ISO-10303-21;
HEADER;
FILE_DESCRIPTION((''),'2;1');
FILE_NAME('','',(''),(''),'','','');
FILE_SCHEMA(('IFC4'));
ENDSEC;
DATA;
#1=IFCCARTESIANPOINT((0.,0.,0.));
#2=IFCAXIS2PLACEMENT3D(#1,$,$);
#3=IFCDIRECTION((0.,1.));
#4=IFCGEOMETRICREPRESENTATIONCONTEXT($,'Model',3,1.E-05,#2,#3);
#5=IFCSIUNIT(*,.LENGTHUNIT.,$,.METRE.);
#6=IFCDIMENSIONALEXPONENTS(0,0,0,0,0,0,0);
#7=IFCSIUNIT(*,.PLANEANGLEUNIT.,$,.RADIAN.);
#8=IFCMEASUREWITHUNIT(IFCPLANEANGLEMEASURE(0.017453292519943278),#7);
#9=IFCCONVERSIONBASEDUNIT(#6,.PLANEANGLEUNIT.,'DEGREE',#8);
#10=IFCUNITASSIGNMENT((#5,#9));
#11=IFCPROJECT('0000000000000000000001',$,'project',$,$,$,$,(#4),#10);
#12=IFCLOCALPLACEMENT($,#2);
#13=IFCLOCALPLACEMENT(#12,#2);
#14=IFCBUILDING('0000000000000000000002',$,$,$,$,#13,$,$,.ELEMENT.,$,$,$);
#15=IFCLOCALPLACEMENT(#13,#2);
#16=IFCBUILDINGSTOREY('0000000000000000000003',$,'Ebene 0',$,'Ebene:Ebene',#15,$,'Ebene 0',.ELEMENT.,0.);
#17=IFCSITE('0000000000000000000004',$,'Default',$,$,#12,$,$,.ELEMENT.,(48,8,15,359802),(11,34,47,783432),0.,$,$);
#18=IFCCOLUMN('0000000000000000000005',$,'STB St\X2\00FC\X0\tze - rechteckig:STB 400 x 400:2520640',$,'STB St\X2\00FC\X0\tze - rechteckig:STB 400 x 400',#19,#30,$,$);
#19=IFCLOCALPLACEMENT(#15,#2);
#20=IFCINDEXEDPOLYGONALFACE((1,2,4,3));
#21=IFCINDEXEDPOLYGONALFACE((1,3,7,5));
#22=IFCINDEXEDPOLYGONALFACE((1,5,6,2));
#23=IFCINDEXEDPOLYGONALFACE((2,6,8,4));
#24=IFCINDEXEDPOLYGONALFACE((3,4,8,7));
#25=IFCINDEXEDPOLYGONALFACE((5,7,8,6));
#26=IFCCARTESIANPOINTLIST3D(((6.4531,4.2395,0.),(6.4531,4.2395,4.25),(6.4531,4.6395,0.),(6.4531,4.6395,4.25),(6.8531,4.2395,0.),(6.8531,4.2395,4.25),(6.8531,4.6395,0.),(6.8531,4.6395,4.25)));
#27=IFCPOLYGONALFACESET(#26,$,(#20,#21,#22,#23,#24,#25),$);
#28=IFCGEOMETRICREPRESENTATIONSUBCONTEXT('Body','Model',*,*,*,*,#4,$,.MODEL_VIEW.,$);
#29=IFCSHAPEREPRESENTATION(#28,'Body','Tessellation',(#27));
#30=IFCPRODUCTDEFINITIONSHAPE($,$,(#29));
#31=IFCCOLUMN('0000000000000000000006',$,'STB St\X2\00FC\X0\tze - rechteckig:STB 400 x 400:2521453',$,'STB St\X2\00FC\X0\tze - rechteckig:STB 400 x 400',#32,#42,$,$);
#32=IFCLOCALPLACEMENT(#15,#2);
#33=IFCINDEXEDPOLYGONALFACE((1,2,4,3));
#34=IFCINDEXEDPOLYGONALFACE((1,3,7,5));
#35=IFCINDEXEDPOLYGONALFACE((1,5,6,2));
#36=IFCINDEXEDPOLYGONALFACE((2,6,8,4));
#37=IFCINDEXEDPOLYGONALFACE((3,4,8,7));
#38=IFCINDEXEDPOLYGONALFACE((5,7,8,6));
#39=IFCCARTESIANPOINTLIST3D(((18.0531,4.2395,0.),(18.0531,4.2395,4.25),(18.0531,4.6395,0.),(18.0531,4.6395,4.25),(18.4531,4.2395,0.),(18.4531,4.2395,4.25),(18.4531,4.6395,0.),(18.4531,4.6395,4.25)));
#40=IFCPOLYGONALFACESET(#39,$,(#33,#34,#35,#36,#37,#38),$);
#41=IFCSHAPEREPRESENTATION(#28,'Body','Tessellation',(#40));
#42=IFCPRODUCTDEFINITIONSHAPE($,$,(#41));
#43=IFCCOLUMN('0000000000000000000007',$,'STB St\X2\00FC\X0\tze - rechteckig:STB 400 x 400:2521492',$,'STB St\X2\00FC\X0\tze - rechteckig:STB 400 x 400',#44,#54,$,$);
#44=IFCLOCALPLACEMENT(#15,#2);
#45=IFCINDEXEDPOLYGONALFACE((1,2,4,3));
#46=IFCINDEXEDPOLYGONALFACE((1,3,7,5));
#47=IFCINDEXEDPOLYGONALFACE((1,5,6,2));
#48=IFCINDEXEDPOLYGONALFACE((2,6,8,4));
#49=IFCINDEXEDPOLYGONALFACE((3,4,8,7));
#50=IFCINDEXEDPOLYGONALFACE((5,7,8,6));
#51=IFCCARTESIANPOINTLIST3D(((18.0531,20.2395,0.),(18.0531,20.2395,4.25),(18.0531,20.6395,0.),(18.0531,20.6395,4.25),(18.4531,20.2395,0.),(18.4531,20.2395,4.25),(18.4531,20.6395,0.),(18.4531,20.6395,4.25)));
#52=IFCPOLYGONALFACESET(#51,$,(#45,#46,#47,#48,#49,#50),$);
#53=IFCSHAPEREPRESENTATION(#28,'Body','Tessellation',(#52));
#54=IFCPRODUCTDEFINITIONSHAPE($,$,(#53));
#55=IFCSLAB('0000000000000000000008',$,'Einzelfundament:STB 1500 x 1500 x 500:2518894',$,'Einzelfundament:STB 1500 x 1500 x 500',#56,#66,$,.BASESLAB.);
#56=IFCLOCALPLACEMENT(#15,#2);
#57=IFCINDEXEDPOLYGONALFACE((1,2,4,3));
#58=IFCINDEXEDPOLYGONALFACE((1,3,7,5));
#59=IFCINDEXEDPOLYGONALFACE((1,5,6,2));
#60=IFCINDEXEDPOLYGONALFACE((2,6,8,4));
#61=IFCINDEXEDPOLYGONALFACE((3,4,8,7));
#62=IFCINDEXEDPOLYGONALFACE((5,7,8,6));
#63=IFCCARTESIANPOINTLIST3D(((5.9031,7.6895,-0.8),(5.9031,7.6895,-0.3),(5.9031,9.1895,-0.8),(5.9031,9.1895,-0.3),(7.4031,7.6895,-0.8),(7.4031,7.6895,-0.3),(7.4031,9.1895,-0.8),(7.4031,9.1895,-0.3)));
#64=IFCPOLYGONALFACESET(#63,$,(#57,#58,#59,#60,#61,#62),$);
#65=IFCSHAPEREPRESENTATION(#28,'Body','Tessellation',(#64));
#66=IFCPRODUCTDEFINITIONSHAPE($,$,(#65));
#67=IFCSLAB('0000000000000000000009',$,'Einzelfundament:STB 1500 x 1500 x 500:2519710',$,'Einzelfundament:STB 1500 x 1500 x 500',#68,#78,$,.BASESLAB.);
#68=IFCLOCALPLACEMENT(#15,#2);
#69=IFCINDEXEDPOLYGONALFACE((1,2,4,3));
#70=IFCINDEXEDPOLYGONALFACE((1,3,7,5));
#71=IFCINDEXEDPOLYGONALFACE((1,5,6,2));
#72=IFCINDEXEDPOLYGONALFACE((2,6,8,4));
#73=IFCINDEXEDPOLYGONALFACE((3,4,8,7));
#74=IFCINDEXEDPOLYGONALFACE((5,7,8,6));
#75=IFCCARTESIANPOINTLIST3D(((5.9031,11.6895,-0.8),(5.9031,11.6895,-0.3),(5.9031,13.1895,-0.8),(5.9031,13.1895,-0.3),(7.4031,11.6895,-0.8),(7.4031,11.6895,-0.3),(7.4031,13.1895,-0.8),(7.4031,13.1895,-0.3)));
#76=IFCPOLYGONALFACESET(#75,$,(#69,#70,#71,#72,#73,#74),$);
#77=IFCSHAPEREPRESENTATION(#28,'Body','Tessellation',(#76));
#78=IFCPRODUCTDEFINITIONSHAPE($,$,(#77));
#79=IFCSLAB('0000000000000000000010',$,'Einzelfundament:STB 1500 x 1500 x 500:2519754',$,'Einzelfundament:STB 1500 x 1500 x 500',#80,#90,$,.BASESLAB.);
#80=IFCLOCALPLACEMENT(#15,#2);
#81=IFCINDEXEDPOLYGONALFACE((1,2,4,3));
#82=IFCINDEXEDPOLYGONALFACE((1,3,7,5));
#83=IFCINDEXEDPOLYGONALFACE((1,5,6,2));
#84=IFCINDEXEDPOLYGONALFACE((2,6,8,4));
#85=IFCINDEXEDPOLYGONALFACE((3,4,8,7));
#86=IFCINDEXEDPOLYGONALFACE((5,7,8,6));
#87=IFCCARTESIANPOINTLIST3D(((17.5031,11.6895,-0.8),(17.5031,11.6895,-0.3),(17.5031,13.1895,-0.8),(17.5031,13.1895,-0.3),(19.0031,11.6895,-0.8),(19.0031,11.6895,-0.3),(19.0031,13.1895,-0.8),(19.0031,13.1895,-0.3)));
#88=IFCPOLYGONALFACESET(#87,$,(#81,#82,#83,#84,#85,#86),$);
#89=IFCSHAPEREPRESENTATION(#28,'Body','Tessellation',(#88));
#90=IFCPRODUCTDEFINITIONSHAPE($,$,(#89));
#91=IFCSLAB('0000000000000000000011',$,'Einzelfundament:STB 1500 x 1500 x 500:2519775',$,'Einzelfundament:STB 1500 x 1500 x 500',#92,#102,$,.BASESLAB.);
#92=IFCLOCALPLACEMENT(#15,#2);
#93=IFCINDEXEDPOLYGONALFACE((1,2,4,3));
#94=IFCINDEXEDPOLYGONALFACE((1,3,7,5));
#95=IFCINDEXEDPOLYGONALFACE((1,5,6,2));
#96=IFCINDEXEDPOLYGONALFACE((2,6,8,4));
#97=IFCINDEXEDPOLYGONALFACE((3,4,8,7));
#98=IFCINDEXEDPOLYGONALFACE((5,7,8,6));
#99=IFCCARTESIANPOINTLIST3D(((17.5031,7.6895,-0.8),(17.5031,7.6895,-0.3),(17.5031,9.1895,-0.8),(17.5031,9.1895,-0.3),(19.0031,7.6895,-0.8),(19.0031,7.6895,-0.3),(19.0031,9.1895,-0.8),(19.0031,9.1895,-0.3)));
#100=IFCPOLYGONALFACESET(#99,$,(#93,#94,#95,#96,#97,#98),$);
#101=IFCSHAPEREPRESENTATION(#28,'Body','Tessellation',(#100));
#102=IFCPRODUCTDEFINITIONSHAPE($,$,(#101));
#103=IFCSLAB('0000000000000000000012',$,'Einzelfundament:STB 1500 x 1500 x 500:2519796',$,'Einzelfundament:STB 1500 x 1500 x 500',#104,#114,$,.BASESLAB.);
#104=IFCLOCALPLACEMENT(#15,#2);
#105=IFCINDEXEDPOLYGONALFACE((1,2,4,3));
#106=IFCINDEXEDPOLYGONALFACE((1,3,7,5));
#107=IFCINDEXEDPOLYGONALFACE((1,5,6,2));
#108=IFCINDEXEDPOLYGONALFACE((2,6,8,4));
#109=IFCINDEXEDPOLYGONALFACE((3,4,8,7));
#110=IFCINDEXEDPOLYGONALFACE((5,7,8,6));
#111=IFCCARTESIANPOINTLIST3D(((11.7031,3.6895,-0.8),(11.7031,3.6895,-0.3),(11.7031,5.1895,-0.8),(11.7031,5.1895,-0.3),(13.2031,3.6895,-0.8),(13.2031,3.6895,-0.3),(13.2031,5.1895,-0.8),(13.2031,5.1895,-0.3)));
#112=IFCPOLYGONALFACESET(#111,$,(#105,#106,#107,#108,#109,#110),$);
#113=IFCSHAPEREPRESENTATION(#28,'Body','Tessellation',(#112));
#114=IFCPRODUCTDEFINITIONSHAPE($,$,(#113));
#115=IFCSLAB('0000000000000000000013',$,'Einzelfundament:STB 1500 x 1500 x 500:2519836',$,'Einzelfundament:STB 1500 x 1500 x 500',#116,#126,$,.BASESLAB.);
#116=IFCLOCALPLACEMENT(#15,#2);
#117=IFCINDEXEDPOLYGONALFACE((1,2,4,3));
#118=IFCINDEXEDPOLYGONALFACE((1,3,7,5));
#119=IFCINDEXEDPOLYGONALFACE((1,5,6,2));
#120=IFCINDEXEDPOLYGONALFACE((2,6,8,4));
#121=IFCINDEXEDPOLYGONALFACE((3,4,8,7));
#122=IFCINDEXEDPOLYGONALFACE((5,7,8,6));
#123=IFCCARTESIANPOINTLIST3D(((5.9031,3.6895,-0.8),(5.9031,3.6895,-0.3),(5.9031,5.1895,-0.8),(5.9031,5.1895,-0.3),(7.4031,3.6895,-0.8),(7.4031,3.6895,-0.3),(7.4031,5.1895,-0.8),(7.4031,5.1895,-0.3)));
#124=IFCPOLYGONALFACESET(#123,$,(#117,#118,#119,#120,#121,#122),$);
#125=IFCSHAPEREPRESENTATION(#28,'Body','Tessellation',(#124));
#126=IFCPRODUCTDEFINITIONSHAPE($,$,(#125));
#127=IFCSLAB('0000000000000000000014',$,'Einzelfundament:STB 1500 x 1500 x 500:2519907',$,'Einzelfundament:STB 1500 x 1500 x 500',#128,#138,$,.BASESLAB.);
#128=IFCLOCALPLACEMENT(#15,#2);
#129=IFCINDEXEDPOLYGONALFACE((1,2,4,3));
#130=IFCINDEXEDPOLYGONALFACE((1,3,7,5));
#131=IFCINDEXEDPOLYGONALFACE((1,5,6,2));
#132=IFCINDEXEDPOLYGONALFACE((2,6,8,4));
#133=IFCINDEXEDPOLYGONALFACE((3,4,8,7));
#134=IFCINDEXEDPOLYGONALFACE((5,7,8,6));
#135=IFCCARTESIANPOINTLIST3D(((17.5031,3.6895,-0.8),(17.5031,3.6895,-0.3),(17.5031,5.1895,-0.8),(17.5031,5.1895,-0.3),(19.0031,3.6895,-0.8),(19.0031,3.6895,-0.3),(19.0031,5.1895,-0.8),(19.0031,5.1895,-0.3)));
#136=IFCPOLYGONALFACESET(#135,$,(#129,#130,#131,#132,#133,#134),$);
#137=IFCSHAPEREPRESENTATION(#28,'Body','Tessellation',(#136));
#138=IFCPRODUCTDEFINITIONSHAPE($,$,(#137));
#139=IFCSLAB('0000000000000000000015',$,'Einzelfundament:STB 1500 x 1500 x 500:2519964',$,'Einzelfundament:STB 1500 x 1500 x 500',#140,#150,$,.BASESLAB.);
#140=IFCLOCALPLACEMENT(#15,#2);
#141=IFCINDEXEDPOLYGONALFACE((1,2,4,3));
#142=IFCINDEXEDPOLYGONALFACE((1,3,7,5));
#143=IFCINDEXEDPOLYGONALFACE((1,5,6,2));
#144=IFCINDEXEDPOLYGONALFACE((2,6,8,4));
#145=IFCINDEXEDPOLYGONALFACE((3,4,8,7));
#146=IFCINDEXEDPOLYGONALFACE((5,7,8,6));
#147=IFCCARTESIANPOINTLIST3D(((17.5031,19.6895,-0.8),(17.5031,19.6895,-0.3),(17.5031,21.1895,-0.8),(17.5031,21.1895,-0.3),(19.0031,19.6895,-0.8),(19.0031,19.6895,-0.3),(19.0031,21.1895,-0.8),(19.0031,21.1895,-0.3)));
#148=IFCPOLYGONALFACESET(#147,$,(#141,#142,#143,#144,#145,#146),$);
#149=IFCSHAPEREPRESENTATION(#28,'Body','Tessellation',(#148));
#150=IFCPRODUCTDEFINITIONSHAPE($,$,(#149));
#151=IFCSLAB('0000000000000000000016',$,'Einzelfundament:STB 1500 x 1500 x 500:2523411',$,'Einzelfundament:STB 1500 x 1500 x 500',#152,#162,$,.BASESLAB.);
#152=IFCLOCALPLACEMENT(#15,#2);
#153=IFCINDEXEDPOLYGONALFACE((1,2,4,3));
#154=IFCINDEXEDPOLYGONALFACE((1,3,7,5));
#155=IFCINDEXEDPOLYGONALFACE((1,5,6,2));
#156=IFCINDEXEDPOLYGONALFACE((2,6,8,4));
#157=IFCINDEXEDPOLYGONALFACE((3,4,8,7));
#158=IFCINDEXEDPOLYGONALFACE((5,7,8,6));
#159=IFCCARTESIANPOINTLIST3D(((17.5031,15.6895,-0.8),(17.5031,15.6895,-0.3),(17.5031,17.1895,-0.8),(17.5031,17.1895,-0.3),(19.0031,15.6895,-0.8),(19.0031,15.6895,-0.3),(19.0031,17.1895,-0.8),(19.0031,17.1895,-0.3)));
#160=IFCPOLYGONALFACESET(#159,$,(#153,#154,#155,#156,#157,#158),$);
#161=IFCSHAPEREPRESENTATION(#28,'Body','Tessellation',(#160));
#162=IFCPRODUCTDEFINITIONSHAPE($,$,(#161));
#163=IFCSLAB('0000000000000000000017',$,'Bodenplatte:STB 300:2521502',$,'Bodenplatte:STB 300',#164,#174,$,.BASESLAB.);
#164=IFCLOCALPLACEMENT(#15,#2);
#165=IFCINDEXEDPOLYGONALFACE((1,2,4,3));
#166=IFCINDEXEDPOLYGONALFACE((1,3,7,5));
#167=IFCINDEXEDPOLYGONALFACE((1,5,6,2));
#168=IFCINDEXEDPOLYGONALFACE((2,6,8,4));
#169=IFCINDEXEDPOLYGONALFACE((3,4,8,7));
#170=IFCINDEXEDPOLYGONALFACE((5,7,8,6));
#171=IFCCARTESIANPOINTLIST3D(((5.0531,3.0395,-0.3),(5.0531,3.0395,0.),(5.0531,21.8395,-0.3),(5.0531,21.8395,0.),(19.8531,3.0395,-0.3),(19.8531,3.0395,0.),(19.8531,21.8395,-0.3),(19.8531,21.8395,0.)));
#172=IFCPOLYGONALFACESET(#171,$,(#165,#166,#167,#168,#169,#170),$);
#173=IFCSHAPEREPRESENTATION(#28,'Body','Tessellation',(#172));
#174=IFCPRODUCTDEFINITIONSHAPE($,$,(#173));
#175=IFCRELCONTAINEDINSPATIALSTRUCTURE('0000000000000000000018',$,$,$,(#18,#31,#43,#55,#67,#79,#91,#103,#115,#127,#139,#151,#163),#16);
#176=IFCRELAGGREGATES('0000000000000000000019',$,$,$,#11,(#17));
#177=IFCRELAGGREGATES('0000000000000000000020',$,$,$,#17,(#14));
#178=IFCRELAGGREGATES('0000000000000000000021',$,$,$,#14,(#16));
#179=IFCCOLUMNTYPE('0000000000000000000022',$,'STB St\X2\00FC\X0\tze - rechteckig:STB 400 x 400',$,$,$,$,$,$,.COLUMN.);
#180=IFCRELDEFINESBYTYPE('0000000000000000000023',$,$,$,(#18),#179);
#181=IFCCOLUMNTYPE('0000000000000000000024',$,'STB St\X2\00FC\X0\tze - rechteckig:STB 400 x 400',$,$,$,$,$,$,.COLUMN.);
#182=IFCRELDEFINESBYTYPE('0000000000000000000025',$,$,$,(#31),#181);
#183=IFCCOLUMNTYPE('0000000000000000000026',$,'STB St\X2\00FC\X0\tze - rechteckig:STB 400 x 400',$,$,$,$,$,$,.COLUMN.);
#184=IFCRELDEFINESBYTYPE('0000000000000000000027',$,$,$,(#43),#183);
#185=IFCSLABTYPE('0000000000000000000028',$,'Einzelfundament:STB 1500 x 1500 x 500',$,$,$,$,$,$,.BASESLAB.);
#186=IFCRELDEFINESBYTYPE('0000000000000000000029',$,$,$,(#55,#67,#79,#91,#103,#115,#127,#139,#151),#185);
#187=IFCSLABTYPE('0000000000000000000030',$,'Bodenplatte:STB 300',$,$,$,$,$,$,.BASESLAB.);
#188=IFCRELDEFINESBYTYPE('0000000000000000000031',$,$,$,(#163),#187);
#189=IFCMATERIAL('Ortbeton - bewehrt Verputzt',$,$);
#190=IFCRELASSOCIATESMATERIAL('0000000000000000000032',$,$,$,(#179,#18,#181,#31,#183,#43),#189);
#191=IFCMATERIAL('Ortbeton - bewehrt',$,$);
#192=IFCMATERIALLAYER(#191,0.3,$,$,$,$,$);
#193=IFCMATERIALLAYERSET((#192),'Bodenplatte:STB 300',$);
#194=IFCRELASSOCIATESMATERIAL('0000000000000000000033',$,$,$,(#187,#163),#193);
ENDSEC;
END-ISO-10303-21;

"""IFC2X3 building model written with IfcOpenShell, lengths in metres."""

from ifc_helpers import new_model, entity, si_unit, converted_unit, direction, frame, frame_2d, origin, origin_2d_with_axis, place, context, subcontext, project, spatial, rectangle, extrude, source, transform, mapped, material, layer, layer_set, layer_usage, type_object, type_shapes, element, save


model = new_model("IFC2X3")

# Units and contexts
model_context = context("Model", 3, precision=1e-05, world=origin(), true_north=direction((0.0, 1.0)))
body_context = subcontext(model_context, "Body", "Model", "MODEL_VIEW")
ifc_project = project(units=[si_unit("LENGTHUNIT", "METRE"), converted_unit("PLANEANGLEUNIT", "DEGREE", entity("IfcPlaneAngleMeasure", 0.017453292519943278), si_unit("PLANEANGLEUNIT", "RADIAN"), dimensions=[0, 0, 0, 0, 0, 0, 0])], contexts=[model_context])

# Site, building, storey
site_placement = place(None, origin())
site = spatial("IfcSite", under=ifc_project, at=site_placement, Name="Default", CompositionType="ELEMENT", RefLatitude=(48, 8, 15, 359802), RefLongitude=(11, 34, 47, 783432), RefElevation=0.0)
building_placement = place(site_placement, origin())
building = spatial("IfcBuilding", under=site, at=building_placement, CompositionType="ELEMENT")
storey_placement = place(building_placement, origin())
storey = spatial("IfcBuildingStorey", under=building, at=storey_placement, Name="Ebene 0", ObjectType="Ebene:Ebene", LongName="Ebene 0", CompositionType="ELEMENT", Elevation=0.0)

# Columns
ifc_material_1 = material(Name="Ortbeton - bewehrt Verputzt")
column_type_1 = type_object("IfcColumnType", Name="STB Stütze - rechteckig:STB 400 x 400", PredefinedType="COLUMN", material=ifc_material_1)
shared_shape_1 = source(origin(), body_context, "Body", "SweptSolid", [
    extrude(rectangle(XDim=0.4, YDim=0.4, at=origin_2d_with_axis()), frame((6.6531, 4.4395, 0.0), z_axis=(0.0, 0.0, 1.0), x_axis=(-1.0, 0.0, 0.0)), (0.0, 0.0, 1.0), 4.25),
])
type_shapes(column_type_1, [shared_shape_1])
column_1_placement = place(storey_placement, origin())
element("IfcColumn", 1, at=column_1_placement, inside=storey, type_object=column_type_1, material=ifc_material_1, Name="STB Stütze - rechteckig:STB 400 x 400:2520640", ObjectType="STB Stütze - rechteckig:STB 400 x 400", context=body_context, shape_type="MappedRepresentation", body=[
    mapped(shared_shape_1, transform((0.0, 0.0, 0.0), scale=1.0)),
])
column_type_2 = type_object("IfcColumnType", Name="STB Stütze - rechteckig:STB 400 x 400", PredefinedType="COLUMN", material=ifc_material_1)
shared_shape_2 = source(origin(), body_context, "Body", "SweptSolid", [
    extrude(rectangle(XDim=0.4, YDim=0.4, at=origin_2d_with_axis()), frame((18.2531, 4.4395, 0.0), z_axis=(0.0, 0.0, 1.0), x_axis=(-1.0, 0.0, 0.0)), (0.0, 0.0, 1.0), 4.25),
])
type_shapes(column_type_2, [shared_shape_2])
column_2_placement = place(storey_placement, origin())
element("IfcColumn", 2, at=column_2_placement, inside=storey, type_object=column_type_2, material=ifc_material_1, Name="STB Stütze - rechteckig:STB 400 x 400:2521453", ObjectType="STB Stütze - rechteckig:STB 400 x 400", context=body_context, shape_type="MappedRepresentation", body=[
    mapped(shared_shape_2, transform((0.0, 0.0, 0.0), scale=1.0)),
])
column_type_3 = type_object("IfcColumnType", Name="STB Stütze - rechteckig:STB 400 x 400", PredefinedType="COLUMN", material=ifc_material_1)
shared_shape_3 = source(origin(), body_context, "Body", "SweptSolid", [
    extrude(rectangle(XDim=0.4, YDim=0.4, at=frame_2d((0.0, 0.0), x_axis=(1.0, 0.0))), frame((18.2531, 20.4395, 0.0), z_axis=(0.0, 0.0, 1.0), x_axis=(-1.0, 0.0, 0.0)), (0.0, 0.0, 1.0), 4.25),
])
type_shapes(column_type_3, [shared_shape_3])
column_3_placement = place(storey_placement, origin())
element("IfcColumn", 3, at=column_3_placement, inside=storey, type_object=column_type_3, material=ifc_material_1, Name="STB Stütze - rechteckig:STB 400 x 400:2521492", ObjectType="STB Stütze - rechteckig:STB 400 x 400", context=body_context, shape_type="MappedRepresentation", body=[
    mapped(shared_shape_3, transform((0.0, 0.0, 0.0), scale=1.0)),
])

# Slabs
slab_type_1 = type_object("IfcSlabType", Name="Einzelfundament:STB 1500 x 1500 x 500", PredefinedType="BASESLAB")
slab_1_placement = place(storey_placement, origin())
element("IfcSlab", 4, at=slab_1_placement, inside=storey, type_object=slab_type_1, Name="Einzelfundament:STB 1500 x 1500 x 500:2518894", ObjectType="Einzelfundament:STB 1500 x 1500 x 500", PredefinedType="BASESLAB", context=body_context, shape_type="SweptSolid", body=[
    extrude(rectangle(XDim=1.5, YDim=1.5, at=frame_2d((0.0, 0.0), x_axis=(1.0, 0.0))), frame((6.6531, 8.4395, -0.8), z_axis=(0.0, 0.0, 1.0), x_axis=(-1.0, 0.0, 0.0)), (0.0, 0.0, 1.0), 0.5),
])
slab_2_placement = place(storey_placement, origin())
element("IfcSlab", 5, at=slab_2_placement, inside=storey, type_object=slab_type_1, Name="Einzelfundament:STB 1500 x 1500 x 500:2519710", ObjectType="Einzelfundament:STB 1500 x 1500 x 500", PredefinedType="BASESLAB", context=body_context, shape_type="SweptSolid", body=[
    extrude(rectangle(XDim=1.5, YDim=1.5, at=frame_2d((0.0, 0.0), x_axis=(1.0, 0.0))), frame((6.6531, 12.4395, -0.8), z_axis=(0.0, 0.0, 1.0), x_axis=(-1.0, 0.0, 0.0)), (0.0, 0.0, 1.0), 0.5),
])
slab_3_placement = place(storey_placement, origin())
element("IfcSlab", 6, at=slab_3_placement, inside=storey, type_object=slab_type_1, Name="Einzelfundament:STB 1500 x 1500 x 500:2519754", ObjectType="Einzelfundament:STB 1500 x 1500 x 500", PredefinedType="BASESLAB", context=body_context, shape_type="SweptSolid", body=[
    extrude(rectangle(XDim=1.5, YDim=1.5, at=frame_2d((0.0, 0.0), x_axis=(1.0, 0.0))), frame((18.2531, 12.4395, -0.8), z_axis=(0.0, 0.0, 1.0), x_axis=(-1.0, 0.0, 0.0)), (0.0, 0.0, 1.0), 0.5),
])
slab_4_placement = place(storey_placement, origin())
element("IfcSlab", 7, at=slab_4_placement, inside=storey, type_object=slab_type_1, Name="Einzelfundament:STB 1500 x 1500 x 500:2519775", ObjectType="Einzelfundament:STB 1500 x 1500 x 500", PredefinedType="BASESLAB", context=body_context, shape_type="SweptSolid", body=[
    extrude(rectangle(XDim=1.5, YDim=1.5, at=frame_2d((0.0, 0.0), x_axis=(1.0, 0.0))), frame((18.2531, 8.4395, -0.8), z_axis=(0.0, 0.0, 1.0), x_axis=(-1.0, 0.0, 0.0)), (0.0, 0.0, 1.0), 0.5),
])
slab_5_placement = place(storey_placement, origin())
element("IfcSlab", 8, at=slab_5_placement, inside=storey, type_object=slab_type_1, Name="Einzelfundament:STB 1500 x 1500 x 500:2519796", ObjectType="Einzelfundament:STB 1500 x 1500 x 500", PredefinedType="BASESLAB", context=body_context, shape_type="SweptSolid", body=[
    extrude(rectangle(XDim=1.5, YDim=1.5, at=frame_2d((0.0, 0.0), x_axis=(1.0, 0.0))), frame((12.4531, 4.4395, -0.8), z_axis=(0.0, 0.0, 1.0), x_axis=(0.0, 1.0, 0.0)), (0.0, 0.0, 1.0), 0.5),
])
slab_6_placement = place(storey_placement, origin())
element("IfcSlab", 9, at=slab_6_placement, inside=storey, type_object=slab_type_1, Name="Einzelfundament:STB 1500 x 1500 x 500:2519836", ObjectType="Einzelfundament:STB 1500 x 1500 x 500", PredefinedType="BASESLAB", context=body_context, shape_type="SweptSolid", body=[
    extrude(rectangle(XDim=1.5, YDim=1.5, at=frame_2d((0.0, 0.0), x_axis=(1.0, 0.0))), frame((6.6531, 4.4395, -0.8), z_axis=(0.0, 0.0, 1.0), x_axis=(-1.0, 0.0, 0.0)), (0.0, 0.0, 1.0), 0.5),
])
slab_7_placement = place(storey_placement, origin())
element("IfcSlab", 10, at=slab_7_placement, inside=storey, type_object=slab_type_1, Name="Einzelfundament:STB 1500 x 1500 x 500:2519907", ObjectType="Einzelfundament:STB 1500 x 1500 x 500", PredefinedType="BASESLAB", context=body_context, shape_type="SweptSolid", body=[
    extrude(rectangle(XDim=1.5, YDim=1.5, at=frame_2d((0.0, 0.0), x_axis=(1.0, 0.0))), frame((18.2531, 4.4395, -0.8), z_axis=(0.0, 0.0, 1.0), x_axis=(-1.0, 0.0, 0.0)), (0.0, 0.0, 1.0), 0.5),
])
slab_8_placement = place(storey_placement, origin())
element("IfcSlab", 11, at=slab_8_placement, inside=storey, type_object=slab_type_1, Name="Einzelfundament:STB 1500 x 1500 x 500:2519964", ObjectType="Einzelfundament:STB 1500 x 1500 x 500", PredefinedType="BASESLAB", context=body_context, shape_type="SweptSolid", body=[
    extrude(rectangle(XDim=1.5, YDim=1.5, at=frame_2d((0.0, 0.0), x_axis=(1.0, 0.0))), frame((18.2531, 20.4395, -0.8), z_axis=(0.0, 0.0, 1.0), x_axis=(-1.0, 0.0, 0.0)), (0.0, 0.0, 1.0), 0.5),
])
slab_9_placement = place(storey_placement, origin())
element("IfcSlab", 12, at=slab_9_placement, inside=storey, type_object=slab_type_1, Name="Einzelfundament:STB 1500 x 1500 x 500:2523411", ObjectType="Einzelfundament:STB 1500 x 1500 x 500", PredefinedType="BASESLAB", context=body_context, shape_type="SweptSolid", body=[
    extrude(rectangle(XDim=1.5, YDim=1.5, at=frame_2d((0.0, 0.0), x_axis=(1.0, 0.0))), frame((18.2531, 16.4395, -0.8), z_axis=(0.0, 0.0, 1.0), x_axis=(-1.0, 0.0, 0.0)), (0.0, 0.0, 1.0), 0.5),
])
ifc_material_2 = material(Name="Ortbeton - bewehrt")
ifc_layer = layer(ifc_material_2, 0.3)
ifc_layer_set = layer_set([ifc_layer], Name="Bodenplatte:STB 300")
ifc_layer_usage = layer_usage(ifc_layer_set, "AXIS3", "POSITIVE", 0.0)
slab_type_2 = type_object("IfcSlabType", Name="Bodenplatte:STB 300", PredefinedType="BASESLAB", material=ifc_layer_set)
slab_10_placement = place(storey_placement, origin())
element("IfcSlab", 13, at=slab_10_placement, inside=storey, type_object=slab_type_2, material=ifc_layer_usage, Name="Bodenplatte:STB 300:2521502", ObjectType="Bodenplatte:STB 300", PredefinedType="BASESLAB", context=body_context, shape_type="SweptSolid", body=[
    extrude(rectangle(XDim=18.8, YDim=14.8, at=origin_2d_with_axis()), frame((12.4531, 12.4395, 0.0), z_axis=(0.0, 0.0, -1.0), x_axis=(0.0, 1.0, 0.0)), (0.0, 0.0, 1.0), 0.3),
])

save(model, "model.ifc")
